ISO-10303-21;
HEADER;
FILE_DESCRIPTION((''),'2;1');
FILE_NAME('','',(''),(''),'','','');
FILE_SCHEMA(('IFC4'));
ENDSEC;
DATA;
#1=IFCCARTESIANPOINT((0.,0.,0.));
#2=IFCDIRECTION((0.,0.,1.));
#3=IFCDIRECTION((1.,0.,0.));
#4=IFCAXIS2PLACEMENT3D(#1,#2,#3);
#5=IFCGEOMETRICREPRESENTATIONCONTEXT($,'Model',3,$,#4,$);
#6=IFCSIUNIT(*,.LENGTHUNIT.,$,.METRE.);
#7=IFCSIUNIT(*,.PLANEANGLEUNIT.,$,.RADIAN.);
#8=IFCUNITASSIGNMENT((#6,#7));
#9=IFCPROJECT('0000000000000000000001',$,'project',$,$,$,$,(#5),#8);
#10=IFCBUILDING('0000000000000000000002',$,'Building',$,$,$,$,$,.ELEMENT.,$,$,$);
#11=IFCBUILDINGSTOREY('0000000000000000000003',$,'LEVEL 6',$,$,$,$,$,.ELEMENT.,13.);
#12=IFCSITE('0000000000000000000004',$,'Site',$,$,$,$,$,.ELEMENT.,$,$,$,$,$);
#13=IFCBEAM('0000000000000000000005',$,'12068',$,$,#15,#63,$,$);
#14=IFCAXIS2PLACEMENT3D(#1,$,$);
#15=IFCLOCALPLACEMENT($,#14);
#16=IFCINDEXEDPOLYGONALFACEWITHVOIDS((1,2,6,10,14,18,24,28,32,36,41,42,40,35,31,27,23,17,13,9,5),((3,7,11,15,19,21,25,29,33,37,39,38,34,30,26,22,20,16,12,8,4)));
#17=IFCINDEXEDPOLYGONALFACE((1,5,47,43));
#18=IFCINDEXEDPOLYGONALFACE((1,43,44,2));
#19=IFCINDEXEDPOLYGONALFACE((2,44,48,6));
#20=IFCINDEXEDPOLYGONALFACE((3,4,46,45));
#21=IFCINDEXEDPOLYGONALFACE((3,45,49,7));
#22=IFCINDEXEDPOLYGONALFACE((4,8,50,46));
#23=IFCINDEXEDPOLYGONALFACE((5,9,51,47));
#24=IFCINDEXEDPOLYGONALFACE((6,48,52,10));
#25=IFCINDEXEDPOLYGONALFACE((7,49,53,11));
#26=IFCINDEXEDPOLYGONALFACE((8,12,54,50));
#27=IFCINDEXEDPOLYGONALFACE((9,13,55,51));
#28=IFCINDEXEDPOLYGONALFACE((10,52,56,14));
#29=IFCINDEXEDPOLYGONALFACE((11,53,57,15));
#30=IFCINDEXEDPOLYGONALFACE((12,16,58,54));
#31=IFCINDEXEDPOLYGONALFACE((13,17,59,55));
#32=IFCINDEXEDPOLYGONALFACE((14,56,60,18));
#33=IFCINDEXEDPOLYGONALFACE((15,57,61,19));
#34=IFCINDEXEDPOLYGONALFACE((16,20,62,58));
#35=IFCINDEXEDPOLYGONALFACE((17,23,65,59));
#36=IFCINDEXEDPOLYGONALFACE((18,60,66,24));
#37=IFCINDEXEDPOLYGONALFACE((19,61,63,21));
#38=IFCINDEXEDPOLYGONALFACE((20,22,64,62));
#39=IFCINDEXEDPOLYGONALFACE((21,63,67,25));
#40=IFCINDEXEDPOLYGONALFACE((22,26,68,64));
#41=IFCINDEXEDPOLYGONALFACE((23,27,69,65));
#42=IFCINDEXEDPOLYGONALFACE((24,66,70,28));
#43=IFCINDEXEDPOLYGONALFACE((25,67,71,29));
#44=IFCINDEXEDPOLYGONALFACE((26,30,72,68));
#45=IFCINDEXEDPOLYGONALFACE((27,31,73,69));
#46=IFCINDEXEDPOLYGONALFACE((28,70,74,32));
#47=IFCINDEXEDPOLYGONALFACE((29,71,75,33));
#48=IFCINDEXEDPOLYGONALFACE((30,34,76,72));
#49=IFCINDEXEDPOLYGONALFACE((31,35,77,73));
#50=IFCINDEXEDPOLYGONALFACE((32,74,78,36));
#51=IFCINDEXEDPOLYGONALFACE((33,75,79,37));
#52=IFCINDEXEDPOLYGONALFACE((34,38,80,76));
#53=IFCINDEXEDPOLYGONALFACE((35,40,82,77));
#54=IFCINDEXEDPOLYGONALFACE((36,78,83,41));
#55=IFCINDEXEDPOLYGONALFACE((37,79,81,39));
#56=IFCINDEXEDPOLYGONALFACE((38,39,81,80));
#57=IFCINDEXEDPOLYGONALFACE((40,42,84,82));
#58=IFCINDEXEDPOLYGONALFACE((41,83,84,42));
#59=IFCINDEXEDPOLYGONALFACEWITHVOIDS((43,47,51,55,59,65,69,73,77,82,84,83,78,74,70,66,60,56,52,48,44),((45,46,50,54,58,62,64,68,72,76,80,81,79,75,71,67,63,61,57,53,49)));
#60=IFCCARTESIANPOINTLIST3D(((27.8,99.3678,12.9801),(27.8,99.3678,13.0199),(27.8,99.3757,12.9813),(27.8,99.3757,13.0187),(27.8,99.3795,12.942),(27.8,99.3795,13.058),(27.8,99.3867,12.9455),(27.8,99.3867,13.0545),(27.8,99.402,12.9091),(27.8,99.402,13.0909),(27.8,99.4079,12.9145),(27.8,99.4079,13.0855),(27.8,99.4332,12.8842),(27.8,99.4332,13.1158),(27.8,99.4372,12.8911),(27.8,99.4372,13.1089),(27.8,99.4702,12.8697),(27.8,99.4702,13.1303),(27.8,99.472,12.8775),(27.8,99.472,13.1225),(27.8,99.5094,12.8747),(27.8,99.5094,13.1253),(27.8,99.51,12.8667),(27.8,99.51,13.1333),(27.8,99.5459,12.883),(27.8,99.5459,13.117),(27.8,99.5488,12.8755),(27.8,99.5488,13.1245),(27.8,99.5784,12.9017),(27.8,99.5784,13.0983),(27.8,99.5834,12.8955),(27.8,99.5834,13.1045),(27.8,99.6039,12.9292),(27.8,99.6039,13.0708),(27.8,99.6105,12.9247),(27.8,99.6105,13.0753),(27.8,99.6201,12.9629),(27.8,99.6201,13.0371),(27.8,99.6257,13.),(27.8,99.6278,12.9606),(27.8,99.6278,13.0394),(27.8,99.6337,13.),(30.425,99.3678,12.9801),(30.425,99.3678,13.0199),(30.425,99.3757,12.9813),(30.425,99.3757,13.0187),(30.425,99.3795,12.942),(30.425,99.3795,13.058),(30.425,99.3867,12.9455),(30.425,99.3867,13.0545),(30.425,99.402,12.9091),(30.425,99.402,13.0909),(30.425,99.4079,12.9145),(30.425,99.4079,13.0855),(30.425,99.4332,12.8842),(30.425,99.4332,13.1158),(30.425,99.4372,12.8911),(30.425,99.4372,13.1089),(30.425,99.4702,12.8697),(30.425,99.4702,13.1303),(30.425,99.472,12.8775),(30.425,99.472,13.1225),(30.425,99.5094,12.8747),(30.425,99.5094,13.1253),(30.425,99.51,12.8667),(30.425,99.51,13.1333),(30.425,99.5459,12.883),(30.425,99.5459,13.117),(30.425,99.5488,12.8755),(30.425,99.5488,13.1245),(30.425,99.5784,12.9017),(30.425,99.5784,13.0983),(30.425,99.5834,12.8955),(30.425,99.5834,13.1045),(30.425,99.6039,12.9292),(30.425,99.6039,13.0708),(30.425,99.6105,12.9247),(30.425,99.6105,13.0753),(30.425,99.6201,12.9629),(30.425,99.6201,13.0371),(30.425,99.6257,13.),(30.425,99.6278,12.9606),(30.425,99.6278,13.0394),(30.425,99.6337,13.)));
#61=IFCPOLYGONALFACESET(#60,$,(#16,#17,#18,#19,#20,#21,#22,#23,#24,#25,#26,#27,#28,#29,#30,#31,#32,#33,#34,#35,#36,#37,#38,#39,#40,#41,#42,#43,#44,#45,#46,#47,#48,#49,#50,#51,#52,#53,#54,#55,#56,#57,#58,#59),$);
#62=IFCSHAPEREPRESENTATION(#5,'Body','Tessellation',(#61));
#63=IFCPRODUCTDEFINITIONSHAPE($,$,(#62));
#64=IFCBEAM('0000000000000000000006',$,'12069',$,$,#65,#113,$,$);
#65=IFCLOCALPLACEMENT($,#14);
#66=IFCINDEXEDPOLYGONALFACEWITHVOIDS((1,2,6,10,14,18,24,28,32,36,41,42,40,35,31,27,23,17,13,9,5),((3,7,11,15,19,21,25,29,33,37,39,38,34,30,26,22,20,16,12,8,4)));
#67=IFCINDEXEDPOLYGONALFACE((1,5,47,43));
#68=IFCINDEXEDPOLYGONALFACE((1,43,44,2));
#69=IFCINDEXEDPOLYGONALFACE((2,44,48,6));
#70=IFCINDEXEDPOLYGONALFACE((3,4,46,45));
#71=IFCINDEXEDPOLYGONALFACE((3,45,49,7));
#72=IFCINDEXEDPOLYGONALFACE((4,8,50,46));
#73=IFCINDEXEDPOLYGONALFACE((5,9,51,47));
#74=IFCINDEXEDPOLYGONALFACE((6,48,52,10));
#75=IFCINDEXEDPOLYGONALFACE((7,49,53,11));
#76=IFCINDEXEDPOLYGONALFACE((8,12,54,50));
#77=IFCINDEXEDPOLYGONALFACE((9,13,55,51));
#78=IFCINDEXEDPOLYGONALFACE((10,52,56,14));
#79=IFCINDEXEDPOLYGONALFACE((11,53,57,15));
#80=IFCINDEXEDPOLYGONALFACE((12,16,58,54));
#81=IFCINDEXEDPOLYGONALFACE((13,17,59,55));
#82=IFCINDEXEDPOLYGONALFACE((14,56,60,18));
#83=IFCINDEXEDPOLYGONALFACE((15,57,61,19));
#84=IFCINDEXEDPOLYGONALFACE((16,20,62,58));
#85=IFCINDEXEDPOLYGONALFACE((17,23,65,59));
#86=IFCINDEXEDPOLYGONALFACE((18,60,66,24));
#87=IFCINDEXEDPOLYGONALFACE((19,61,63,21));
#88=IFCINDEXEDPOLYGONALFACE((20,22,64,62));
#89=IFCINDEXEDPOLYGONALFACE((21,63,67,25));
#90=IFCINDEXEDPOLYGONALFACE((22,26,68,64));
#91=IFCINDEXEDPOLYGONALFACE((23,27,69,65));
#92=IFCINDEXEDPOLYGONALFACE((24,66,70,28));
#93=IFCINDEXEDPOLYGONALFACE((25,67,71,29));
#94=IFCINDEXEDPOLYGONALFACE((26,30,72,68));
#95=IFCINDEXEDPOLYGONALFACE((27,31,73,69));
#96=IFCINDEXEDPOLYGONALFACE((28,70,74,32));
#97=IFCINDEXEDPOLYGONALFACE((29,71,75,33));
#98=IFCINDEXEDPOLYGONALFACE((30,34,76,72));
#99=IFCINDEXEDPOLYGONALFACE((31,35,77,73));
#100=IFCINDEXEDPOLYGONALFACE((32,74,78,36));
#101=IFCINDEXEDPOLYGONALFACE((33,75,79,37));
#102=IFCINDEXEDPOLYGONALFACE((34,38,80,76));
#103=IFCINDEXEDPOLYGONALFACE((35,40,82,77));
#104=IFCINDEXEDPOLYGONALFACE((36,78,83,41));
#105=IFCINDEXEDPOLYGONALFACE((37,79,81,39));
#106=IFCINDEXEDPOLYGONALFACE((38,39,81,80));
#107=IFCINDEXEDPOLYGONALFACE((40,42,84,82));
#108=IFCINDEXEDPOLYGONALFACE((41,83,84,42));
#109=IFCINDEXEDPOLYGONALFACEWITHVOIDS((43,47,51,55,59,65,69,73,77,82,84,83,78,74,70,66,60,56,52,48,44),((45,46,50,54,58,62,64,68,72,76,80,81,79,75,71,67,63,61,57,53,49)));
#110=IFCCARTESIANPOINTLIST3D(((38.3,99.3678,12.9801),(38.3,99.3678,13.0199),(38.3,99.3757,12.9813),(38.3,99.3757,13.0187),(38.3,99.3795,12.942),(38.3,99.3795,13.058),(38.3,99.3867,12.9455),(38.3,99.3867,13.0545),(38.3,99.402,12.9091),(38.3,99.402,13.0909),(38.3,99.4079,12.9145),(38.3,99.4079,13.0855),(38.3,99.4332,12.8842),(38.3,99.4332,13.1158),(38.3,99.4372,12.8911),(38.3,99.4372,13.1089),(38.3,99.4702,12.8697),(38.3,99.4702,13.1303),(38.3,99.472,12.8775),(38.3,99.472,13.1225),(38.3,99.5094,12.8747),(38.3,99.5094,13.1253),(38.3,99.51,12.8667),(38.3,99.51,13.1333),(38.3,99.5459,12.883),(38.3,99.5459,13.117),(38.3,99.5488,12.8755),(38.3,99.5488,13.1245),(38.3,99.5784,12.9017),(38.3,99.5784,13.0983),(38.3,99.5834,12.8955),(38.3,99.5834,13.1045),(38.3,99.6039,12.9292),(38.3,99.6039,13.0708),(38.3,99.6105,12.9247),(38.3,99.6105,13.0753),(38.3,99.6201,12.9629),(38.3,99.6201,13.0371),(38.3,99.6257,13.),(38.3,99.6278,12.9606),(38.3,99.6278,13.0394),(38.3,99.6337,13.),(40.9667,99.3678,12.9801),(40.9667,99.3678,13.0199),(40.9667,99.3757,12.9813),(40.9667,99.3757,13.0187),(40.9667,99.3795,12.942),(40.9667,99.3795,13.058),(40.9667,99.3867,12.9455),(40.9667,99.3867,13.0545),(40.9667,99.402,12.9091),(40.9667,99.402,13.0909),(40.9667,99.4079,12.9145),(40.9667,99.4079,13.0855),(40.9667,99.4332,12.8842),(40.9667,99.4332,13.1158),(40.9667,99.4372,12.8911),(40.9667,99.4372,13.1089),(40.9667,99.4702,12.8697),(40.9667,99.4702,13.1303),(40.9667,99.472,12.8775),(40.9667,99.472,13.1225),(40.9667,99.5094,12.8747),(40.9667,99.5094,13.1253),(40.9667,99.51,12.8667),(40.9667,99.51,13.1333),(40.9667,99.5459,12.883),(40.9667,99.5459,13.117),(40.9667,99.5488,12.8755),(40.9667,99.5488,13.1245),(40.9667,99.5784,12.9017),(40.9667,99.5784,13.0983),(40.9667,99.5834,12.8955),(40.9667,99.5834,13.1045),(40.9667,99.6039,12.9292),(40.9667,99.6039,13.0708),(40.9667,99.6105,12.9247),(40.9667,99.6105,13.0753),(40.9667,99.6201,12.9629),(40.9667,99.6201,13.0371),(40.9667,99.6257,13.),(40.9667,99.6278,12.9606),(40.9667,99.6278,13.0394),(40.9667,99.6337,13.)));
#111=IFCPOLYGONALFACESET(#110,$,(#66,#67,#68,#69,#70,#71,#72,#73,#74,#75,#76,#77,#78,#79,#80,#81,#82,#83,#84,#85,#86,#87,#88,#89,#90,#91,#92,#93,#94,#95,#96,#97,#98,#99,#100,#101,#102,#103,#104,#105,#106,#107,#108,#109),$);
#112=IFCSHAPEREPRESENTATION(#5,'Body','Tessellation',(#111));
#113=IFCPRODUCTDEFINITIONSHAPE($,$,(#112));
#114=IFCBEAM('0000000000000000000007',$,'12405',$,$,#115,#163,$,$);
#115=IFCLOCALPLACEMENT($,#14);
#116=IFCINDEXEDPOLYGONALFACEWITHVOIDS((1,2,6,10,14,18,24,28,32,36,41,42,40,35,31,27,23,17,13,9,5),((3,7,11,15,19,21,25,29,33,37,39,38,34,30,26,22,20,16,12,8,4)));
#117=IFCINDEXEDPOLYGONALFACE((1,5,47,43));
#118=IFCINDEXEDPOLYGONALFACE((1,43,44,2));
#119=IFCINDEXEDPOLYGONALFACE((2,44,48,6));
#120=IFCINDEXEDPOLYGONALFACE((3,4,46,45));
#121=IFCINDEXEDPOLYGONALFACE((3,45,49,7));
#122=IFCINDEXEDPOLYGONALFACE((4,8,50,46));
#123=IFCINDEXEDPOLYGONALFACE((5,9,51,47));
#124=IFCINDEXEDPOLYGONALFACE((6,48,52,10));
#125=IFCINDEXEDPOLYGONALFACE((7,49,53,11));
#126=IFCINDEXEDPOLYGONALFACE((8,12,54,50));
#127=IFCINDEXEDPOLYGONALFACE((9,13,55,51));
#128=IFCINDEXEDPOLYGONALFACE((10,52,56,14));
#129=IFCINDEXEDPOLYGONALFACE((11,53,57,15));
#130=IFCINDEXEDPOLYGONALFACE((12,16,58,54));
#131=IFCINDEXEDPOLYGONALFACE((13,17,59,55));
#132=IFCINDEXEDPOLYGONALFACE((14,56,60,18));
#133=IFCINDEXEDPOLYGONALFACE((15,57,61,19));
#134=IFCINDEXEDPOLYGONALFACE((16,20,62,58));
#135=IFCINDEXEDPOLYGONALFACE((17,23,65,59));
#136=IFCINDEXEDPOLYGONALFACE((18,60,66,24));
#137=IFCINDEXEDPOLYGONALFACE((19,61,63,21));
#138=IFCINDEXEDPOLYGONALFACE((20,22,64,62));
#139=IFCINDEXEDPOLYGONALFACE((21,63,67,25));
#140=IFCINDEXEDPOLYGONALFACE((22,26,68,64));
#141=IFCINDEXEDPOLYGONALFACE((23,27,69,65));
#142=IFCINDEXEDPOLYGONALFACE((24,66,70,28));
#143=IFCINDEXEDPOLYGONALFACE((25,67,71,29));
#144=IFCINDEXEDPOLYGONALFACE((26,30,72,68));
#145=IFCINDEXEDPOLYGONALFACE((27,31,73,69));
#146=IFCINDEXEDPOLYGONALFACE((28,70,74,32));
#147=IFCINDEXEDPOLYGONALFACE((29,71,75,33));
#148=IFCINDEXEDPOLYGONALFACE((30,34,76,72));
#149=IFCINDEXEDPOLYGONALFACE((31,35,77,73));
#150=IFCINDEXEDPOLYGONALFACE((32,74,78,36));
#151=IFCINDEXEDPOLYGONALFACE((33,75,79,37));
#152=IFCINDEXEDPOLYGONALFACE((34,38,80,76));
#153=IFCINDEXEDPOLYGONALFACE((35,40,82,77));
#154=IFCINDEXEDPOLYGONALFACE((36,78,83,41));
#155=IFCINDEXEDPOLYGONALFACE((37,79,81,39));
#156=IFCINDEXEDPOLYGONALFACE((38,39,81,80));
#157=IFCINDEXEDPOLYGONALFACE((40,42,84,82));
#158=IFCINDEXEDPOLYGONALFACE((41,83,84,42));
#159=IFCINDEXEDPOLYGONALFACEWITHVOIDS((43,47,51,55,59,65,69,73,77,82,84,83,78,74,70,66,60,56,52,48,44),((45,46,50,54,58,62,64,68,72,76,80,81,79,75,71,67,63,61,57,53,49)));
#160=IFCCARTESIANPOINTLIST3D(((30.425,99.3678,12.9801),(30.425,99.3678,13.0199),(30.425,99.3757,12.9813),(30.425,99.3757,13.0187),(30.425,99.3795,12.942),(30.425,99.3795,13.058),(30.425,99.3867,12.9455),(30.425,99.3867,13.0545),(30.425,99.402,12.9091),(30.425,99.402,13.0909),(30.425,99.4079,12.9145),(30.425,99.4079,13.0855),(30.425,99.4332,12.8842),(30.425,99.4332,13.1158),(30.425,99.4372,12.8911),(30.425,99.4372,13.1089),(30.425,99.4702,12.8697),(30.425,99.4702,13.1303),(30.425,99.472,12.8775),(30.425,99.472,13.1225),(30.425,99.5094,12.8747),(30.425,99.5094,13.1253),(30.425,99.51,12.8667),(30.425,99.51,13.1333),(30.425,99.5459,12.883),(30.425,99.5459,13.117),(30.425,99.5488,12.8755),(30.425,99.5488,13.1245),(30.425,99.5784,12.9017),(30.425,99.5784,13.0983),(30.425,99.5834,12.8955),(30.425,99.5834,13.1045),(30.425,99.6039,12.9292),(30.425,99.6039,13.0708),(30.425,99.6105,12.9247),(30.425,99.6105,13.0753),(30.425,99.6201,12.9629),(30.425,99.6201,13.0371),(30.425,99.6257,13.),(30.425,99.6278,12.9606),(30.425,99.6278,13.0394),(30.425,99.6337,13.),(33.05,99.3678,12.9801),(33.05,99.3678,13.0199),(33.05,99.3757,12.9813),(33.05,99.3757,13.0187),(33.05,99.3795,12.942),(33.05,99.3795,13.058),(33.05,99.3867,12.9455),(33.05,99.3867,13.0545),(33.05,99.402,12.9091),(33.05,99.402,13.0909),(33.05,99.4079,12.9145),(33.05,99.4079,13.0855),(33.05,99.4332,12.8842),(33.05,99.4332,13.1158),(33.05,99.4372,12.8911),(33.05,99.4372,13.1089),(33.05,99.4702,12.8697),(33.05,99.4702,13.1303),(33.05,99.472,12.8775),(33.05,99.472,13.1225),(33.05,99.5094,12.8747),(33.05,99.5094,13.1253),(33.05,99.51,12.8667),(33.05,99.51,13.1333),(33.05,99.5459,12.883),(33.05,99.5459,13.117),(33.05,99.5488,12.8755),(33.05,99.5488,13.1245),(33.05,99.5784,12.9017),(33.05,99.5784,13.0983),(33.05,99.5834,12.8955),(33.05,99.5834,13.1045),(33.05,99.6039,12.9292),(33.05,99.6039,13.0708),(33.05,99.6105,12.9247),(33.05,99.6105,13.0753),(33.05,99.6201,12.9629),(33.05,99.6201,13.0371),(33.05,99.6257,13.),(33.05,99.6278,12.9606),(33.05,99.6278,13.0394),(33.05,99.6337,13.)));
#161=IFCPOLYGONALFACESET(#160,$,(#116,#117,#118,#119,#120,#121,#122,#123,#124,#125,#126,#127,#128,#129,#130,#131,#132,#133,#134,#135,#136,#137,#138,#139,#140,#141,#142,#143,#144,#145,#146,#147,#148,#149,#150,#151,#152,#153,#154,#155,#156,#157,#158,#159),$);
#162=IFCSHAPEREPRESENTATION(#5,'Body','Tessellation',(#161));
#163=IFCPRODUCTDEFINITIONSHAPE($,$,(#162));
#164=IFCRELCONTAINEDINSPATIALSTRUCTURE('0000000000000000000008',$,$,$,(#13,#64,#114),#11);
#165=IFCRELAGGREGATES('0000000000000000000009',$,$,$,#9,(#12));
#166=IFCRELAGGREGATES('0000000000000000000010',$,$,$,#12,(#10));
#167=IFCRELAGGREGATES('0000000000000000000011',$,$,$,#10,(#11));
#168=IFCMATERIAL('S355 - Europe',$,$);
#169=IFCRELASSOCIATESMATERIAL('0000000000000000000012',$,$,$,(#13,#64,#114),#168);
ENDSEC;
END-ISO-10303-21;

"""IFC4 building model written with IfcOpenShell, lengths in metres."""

from ifc_helpers import new_model, si_unit, frame, origin_with_axes, origin_2d_with_axis, place, context, project, spatial, hollow_circle, extrude, material, material_profile, profile_set, profile_usage, element, save


model = new_model("IFC4")

# Units and contexts
model_context = context("Model", 3, world=origin_with_axes())
ifc_project = project(units=[si_unit("LENGTHUNIT", "METRE"), si_unit("PLANEANGLEUNIT", "RADIAN")], contexts=[model_context])

# Site, building, storey
site = spatial("IfcSite", under=ifc_project, Name="Site", CompositionType="ELEMENT")
building = spatial("IfcBuilding", under=site, Name="Building", CompositionType="ELEMENT")
storey = spatial("IfcBuildingStorey", under=building, Name="LEVEL 6", CompositionType="ELEMENT", Elevation=13.0)

# Shared definitions
ifc_material = material(Name="S355 - Europe")

# Beams
ifc_material_profile_1 = material_profile(ifc_material, hollow_circle(Radius=0.1337, WallThickness=0.008, at=origin_2d_with_axis()))
ifc_profile_set_1 = profile_set([ifc_material_profile_1])
ifc_profile_usage_1 = profile_usage(ifc_profile_set_1, cardinal=10)
beam_1_placement = place(None, frame((27.8, 99.5, 13.0), z_axis=(1.0, 0.0, 0.0), x_axis=(0.0, 1.0, 0.0)))
element("IfcBeam", 1, at=beam_1_placement, inside=storey, material=ifc_profile_usage_1, Name="12068", context=model_context, shape_type="SweptSolid", body=[
    extrude(hollow_circle(Radius=0.1337, WallThickness=0.008, at=origin_2d_with_axis()), origin_with_axes(), (0.0, 0.0, 1.0), 2.625),
])
ifc_material_profile_2 = material_profile(ifc_material, hollow_circle(Radius=0.1337, WallThickness=0.008, at=origin_2d_with_axis()))
ifc_profile_set_2 = profile_set([ifc_material_profile_2])
ifc_profile_usage_2 = profile_usage(ifc_profile_set_2, cardinal=10)
beam_2_placement = place(None, frame((38.3, 99.5, 13.0), z_axis=(1.0, 0.0, 0.0), x_axis=(0.0, 1.0, 0.0)))
element("IfcBeam", 2, at=beam_2_placement, inside=storey, material=ifc_profile_usage_2, Name="12069", context=model_context, shape_type="SweptSolid", body=[
    extrude(hollow_circle(Radius=0.1337, WallThickness=0.008, at=origin_2d_with_axis()), origin_with_axes(), (0.0, 0.0, 1.0), 2.6667),
])
ifc_material_profile_3 = material_profile(ifc_material, hollow_circle(Radius=0.1337, WallThickness=0.008, at=origin_2d_with_axis()))
ifc_profile_set_3 = profile_set([ifc_material_profile_3])
ifc_profile_usage_3 = profile_usage(ifc_profile_set_3, cardinal=10)
beam_3_placement = place(None, frame((30.425, 99.5, 13.0), z_axis=(1.0, 0.0, 0.0), x_axis=(0.0, 1.0, 0.0)))
element("IfcBeam", 3, at=beam_3_placement, inside=storey, material=ifc_profile_usage_3, Name="12405", context=model_context, shape_type="SweptSolid", body=[
    extrude(hollow_circle(Radius=0.1337, WallThickness=0.008, at=origin_2d_with_axis()), origin_with_axes(), (0.0, 0.0, 1.0), 2.625),
])

save(model, "model.ifc")
